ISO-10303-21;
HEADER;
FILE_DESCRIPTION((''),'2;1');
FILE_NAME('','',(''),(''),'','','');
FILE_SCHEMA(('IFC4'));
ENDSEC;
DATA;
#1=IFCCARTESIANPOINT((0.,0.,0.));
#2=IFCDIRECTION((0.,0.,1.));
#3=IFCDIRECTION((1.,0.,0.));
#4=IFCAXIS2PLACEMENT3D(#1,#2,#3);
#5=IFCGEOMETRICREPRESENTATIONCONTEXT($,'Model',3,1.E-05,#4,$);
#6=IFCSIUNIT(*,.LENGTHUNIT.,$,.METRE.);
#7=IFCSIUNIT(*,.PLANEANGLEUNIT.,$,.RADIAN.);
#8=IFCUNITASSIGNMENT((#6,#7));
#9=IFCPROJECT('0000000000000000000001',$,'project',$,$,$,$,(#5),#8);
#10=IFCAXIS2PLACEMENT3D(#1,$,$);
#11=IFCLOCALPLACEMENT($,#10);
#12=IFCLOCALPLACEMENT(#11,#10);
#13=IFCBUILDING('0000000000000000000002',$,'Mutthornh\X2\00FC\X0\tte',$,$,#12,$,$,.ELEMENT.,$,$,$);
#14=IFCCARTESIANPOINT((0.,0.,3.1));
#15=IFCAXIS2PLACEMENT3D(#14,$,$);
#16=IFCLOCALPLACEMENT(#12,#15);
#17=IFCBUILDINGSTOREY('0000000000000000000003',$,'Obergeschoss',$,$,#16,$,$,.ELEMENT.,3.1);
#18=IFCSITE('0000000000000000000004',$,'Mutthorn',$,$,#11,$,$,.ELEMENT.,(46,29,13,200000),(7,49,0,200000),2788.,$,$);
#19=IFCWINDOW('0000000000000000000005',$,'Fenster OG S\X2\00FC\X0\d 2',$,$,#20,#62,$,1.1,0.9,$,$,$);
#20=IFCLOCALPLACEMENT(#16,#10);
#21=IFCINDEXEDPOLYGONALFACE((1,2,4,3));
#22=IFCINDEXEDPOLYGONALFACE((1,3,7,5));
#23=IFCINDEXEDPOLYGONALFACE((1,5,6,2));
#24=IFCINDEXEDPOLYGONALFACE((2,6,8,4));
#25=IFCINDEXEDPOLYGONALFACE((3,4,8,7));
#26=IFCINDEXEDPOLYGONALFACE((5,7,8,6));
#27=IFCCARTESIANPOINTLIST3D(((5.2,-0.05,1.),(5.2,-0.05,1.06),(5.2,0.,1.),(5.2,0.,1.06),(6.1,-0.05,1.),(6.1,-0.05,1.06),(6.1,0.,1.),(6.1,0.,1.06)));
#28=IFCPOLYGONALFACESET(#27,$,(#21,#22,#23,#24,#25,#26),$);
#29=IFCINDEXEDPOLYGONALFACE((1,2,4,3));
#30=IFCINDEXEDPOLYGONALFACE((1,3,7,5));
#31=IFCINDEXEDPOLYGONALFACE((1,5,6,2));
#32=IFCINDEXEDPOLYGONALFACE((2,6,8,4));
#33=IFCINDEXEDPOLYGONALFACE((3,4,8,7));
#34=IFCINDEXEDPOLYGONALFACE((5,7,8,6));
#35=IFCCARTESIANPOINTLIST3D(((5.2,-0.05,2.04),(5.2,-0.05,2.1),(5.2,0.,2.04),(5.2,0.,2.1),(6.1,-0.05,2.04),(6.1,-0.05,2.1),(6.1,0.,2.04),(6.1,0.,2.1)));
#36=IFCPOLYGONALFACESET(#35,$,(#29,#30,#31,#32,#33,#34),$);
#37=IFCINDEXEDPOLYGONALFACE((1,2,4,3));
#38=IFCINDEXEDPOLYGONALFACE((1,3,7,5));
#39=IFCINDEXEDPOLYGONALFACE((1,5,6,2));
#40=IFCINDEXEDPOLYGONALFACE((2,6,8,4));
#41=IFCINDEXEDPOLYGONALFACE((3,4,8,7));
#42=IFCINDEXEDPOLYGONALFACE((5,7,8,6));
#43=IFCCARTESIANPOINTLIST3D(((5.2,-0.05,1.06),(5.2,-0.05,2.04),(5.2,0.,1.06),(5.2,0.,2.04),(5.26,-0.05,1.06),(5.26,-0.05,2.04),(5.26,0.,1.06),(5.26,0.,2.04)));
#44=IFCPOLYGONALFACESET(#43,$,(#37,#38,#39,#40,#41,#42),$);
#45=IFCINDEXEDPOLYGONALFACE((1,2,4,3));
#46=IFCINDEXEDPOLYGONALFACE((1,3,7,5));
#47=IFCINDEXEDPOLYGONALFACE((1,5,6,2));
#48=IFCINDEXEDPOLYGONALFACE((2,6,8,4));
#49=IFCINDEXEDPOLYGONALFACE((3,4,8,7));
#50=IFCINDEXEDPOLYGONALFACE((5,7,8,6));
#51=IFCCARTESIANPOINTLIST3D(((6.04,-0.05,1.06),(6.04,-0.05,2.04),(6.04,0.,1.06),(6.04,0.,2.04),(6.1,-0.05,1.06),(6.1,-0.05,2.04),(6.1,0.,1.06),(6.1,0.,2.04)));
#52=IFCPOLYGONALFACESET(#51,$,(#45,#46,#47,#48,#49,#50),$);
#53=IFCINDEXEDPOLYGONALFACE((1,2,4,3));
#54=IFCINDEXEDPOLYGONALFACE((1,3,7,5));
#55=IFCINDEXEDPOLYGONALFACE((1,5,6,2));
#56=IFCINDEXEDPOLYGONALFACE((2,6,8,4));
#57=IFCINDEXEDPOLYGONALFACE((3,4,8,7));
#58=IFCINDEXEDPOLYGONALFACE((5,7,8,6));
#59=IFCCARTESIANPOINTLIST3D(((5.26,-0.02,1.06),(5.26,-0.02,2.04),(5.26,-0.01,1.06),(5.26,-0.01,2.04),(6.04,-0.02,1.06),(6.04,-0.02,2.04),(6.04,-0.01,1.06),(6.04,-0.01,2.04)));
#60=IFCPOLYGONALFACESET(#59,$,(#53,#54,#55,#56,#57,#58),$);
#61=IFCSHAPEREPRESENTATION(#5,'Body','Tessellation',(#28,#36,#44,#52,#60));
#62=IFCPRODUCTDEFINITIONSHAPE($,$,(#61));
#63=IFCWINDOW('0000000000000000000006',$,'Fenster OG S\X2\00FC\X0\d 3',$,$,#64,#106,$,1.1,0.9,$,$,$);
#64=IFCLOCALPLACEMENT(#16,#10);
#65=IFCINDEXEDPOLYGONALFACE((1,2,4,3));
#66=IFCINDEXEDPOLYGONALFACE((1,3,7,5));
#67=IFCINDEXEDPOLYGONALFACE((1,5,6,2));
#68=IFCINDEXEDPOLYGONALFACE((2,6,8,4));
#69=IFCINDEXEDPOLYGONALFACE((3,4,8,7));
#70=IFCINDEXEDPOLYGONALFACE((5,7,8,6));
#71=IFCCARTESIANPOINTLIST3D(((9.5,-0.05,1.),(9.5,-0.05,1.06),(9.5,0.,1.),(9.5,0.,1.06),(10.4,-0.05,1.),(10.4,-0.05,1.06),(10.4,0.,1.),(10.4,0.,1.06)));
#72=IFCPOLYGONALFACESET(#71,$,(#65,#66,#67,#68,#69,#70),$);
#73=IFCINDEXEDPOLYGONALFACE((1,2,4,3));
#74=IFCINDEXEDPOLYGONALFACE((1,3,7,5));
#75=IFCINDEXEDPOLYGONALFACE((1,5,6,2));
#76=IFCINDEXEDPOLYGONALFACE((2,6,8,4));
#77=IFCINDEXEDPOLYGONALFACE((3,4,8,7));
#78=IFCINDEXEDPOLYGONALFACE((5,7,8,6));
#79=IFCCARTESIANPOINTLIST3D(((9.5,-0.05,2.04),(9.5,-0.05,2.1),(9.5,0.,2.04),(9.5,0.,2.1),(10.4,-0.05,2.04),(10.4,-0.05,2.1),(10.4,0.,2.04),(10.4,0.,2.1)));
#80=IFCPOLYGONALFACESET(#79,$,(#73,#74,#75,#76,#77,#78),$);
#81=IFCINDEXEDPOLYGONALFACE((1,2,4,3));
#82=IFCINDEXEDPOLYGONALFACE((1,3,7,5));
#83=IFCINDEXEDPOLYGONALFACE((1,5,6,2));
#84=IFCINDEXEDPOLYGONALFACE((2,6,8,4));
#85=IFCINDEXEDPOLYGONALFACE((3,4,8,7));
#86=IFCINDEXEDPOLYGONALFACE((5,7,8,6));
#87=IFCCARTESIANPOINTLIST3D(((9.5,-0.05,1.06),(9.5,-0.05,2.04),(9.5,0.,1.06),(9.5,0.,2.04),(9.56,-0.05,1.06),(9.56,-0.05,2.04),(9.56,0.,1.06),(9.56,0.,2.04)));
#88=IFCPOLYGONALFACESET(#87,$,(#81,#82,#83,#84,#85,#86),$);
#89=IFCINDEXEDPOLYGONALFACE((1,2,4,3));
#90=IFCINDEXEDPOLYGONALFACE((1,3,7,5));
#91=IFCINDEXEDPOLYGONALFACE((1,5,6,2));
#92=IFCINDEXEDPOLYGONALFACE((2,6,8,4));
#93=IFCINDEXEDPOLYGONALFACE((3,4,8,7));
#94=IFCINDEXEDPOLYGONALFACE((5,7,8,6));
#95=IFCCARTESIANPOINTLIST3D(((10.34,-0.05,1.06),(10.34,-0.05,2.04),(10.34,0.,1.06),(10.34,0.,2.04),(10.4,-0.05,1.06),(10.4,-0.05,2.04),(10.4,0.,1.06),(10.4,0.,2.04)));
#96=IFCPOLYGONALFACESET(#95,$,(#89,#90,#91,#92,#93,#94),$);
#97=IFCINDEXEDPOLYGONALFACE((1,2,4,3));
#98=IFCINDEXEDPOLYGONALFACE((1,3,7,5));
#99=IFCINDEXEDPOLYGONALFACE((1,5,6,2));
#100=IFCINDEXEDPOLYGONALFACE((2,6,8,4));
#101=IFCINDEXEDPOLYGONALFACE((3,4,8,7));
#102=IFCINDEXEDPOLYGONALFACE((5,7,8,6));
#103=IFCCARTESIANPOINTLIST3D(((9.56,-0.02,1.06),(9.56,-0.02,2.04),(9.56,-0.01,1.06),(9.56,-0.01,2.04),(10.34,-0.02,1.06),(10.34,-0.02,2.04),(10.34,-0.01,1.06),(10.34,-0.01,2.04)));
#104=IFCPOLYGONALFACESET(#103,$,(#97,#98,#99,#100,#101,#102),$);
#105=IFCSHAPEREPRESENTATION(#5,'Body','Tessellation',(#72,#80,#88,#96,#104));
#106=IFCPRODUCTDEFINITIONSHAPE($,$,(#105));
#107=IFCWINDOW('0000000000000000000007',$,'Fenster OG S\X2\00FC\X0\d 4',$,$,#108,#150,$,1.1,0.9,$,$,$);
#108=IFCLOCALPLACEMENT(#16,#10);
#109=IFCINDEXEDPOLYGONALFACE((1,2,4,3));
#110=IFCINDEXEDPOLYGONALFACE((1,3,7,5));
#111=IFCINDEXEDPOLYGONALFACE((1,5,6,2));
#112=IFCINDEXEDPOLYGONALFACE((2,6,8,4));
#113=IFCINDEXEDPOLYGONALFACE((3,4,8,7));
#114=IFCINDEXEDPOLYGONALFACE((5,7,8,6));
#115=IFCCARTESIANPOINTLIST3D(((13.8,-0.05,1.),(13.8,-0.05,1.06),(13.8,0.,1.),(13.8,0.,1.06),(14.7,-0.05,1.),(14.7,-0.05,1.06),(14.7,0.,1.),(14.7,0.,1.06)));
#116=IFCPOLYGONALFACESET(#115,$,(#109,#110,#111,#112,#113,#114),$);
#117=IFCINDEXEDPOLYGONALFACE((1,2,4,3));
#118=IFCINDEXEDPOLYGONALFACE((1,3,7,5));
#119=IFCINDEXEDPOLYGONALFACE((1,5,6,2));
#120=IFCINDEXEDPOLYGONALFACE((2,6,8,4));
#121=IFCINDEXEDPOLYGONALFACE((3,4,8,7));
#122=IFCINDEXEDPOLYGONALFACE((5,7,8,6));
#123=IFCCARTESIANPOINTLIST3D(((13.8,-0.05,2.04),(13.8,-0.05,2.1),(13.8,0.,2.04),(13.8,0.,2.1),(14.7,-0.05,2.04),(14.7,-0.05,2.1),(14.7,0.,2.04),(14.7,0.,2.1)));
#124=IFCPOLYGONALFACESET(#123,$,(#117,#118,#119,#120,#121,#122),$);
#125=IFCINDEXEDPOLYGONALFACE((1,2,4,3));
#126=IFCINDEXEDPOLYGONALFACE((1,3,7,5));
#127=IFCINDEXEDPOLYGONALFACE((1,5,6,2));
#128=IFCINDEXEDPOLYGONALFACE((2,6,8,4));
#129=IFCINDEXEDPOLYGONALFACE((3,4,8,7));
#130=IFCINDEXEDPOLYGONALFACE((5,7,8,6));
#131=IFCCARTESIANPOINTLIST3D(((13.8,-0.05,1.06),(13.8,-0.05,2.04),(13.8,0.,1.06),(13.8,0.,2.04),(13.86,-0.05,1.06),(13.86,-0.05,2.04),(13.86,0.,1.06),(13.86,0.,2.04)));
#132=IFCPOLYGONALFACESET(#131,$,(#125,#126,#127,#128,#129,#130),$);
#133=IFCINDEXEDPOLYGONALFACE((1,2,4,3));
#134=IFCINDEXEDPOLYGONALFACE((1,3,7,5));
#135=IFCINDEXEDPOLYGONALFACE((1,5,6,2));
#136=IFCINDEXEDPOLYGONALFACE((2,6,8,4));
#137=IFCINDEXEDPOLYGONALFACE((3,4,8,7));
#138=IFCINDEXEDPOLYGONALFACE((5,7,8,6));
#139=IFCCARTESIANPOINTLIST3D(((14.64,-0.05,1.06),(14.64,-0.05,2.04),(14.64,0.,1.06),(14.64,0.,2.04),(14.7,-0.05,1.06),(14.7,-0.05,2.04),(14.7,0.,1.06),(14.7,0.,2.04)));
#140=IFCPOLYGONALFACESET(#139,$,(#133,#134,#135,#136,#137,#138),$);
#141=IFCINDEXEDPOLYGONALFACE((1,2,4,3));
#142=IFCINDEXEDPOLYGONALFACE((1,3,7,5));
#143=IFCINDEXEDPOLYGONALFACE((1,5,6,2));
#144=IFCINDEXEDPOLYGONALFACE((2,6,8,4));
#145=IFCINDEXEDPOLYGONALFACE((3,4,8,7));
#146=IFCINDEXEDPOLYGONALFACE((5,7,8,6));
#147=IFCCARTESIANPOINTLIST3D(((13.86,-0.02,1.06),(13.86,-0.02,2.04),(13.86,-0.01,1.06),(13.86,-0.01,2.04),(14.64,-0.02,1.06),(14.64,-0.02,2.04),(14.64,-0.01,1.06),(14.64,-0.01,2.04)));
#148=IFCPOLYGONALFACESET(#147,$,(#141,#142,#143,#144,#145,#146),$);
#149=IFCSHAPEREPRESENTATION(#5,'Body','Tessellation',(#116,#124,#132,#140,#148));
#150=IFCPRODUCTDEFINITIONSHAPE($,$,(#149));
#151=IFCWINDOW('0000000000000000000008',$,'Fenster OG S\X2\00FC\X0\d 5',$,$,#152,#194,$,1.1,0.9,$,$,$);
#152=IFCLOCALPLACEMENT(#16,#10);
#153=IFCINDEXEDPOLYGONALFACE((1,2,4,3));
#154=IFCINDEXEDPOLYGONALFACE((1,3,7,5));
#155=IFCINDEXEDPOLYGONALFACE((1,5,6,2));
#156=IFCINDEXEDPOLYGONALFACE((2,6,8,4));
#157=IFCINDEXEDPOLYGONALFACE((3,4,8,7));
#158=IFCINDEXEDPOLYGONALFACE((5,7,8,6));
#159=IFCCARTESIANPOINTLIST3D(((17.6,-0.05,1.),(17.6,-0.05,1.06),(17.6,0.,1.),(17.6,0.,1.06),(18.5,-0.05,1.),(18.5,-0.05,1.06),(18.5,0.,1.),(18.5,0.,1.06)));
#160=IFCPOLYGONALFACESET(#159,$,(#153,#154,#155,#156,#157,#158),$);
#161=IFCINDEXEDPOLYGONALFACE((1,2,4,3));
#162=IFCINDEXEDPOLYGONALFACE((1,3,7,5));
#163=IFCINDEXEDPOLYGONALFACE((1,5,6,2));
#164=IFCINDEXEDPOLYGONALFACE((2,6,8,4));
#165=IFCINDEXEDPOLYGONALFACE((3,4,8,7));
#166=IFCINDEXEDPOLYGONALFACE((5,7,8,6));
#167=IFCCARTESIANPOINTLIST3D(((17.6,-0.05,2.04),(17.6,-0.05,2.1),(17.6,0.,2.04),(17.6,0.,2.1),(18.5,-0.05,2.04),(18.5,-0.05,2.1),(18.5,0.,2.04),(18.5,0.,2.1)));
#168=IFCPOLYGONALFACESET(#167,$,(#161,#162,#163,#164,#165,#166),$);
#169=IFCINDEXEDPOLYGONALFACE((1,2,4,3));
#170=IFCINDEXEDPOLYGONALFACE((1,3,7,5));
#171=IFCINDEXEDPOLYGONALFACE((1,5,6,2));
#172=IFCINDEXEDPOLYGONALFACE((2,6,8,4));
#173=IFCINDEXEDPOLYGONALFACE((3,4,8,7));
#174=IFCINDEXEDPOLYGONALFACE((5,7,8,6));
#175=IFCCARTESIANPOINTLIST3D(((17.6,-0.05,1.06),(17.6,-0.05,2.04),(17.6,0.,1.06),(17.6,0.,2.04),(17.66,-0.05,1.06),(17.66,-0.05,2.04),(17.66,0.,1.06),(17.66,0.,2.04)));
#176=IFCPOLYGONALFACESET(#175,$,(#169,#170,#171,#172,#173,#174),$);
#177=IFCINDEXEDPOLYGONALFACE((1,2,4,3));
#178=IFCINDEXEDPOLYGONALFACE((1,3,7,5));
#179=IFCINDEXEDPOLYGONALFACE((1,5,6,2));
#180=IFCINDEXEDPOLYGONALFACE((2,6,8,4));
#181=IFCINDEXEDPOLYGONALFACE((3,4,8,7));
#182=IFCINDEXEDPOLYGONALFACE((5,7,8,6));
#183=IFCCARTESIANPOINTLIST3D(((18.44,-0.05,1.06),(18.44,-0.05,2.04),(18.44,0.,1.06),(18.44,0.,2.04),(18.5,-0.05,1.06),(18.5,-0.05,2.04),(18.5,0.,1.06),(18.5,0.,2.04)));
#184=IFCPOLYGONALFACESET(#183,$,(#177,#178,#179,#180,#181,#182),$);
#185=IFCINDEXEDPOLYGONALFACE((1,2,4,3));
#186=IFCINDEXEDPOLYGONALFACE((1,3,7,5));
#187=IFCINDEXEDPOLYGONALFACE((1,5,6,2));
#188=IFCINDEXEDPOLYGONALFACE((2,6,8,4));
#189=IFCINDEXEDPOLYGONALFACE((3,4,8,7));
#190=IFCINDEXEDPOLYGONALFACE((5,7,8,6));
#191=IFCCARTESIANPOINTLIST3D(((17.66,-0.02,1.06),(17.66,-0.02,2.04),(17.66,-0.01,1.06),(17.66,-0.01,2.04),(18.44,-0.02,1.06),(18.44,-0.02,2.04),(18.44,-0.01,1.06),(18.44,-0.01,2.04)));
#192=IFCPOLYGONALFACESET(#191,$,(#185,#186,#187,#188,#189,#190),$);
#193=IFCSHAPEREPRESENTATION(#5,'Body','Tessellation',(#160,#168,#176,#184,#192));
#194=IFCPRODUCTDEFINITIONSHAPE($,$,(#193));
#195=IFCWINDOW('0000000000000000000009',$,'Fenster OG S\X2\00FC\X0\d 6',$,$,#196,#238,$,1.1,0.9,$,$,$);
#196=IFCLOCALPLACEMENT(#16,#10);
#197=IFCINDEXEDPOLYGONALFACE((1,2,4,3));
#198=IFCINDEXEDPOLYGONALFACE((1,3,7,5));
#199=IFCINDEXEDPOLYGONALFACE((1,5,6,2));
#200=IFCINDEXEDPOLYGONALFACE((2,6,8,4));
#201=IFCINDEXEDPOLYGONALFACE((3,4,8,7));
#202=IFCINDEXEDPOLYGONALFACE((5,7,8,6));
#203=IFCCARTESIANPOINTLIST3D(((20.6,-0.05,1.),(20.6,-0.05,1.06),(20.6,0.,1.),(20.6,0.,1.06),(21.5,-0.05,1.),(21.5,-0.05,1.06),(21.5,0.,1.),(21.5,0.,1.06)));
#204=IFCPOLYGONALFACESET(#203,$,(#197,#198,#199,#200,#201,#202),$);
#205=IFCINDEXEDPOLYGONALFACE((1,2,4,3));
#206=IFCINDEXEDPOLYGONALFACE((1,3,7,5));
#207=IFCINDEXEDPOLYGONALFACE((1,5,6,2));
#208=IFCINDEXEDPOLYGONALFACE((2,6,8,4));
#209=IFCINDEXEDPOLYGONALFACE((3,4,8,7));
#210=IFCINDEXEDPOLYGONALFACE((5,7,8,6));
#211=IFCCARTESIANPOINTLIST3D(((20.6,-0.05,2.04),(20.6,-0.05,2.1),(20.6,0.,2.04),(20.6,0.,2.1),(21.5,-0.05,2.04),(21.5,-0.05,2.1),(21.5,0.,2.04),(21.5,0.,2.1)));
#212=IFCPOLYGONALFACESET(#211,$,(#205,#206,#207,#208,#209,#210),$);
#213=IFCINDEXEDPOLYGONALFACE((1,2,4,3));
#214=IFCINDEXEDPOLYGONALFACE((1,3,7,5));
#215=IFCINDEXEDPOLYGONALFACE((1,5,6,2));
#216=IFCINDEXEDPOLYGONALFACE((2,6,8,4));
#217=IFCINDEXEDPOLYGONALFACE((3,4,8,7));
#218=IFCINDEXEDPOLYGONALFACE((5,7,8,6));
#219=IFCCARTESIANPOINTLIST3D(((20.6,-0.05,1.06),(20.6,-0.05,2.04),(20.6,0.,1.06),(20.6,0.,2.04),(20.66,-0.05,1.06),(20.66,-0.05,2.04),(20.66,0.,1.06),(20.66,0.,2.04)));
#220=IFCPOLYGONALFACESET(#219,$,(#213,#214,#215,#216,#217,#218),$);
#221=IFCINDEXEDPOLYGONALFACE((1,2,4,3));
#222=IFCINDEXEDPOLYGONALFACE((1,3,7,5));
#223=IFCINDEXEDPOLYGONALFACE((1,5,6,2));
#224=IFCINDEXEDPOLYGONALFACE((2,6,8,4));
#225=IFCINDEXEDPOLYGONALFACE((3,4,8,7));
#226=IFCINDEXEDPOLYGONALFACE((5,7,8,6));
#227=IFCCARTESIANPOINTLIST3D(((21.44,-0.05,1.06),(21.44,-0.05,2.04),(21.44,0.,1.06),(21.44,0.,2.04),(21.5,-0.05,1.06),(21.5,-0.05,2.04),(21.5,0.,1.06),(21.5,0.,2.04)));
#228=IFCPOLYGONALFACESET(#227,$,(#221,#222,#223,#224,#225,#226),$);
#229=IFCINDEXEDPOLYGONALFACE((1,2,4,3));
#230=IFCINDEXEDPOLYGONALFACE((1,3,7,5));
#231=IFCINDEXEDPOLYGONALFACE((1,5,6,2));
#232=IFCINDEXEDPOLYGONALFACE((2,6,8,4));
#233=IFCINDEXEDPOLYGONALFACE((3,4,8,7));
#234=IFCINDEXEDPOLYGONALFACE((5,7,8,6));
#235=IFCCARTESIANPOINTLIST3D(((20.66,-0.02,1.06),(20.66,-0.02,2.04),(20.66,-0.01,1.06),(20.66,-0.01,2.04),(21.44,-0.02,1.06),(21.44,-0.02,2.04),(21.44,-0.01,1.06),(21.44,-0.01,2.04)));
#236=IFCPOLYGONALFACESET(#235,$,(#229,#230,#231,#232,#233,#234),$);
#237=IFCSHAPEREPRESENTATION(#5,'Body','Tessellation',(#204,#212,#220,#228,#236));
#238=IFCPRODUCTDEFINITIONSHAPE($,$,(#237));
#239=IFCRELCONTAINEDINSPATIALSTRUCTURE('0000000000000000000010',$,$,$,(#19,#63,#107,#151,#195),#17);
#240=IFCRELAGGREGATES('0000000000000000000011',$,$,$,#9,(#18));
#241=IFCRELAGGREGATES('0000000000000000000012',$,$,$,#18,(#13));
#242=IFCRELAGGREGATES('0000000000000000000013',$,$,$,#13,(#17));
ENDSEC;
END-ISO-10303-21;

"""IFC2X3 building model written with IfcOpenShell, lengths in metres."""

from ifc_helpers import new_model, si_unit, frame, frame_2d, origin, origin_with_axes, place, context, project, spatial, rectangle, extrude, element, save


model = new_model("IFC2X3")

# Units and contexts
model_context = context("Model", 3, precision=1e-05, world=origin_with_axes())
ifc_project = project(units=[si_unit("LENGTHUNIT", "METRE"), si_unit("PLANEANGLEUNIT", "RADIAN")], contexts=[model_context])

# Site, building, storey
site_placement = place(None, origin())
site = spatial("IfcSite", under=ifc_project, at=site_placement, Name="Mutthorn", CompositionType="ELEMENT", RefLatitude=(46, 29, 13, 200000), RefLongitude=(7, 49, 0, 200000), RefElevation=2788.0)
building_placement = place(site_placement, origin())
building = spatial("IfcBuilding", under=site, at=building_placement, Name="Mutthornhütte", CompositionType="ELEMENT")
storey_placement = place(building_placement, frame((0.0, 0.0, 3.1)))
storey = spatial("IfcBuildingStorey", under=building, at=storey_placement, Name="Obergeschoss", CompositionType="ELEMENT", Elevation=3.1)

# Windows
window_1_placement = place(storey_placement, origin())
element("IfcWindow", 1, at=window_1_placement, inside=storey, Name="Fenster OG Süd 2", OverallHeight=1.1, OverallWidth=0.9, context=model_context, shape_type="SweptSolid", body=[
    extrude(rectangle(XDim=0.9, YDim=0.05, at=frame_2d((0.45, 0.025))), frame((5.2, -0.05, 1.0)), (0.0, 0.0, 1.0), 0.06),
    extrude(rectangle(XDim=0.9, YDim=0.05, at=frame_2d((0.45, 0.025))), frame((5.2, -0.05, 2.04)), (0.0, 0.0, 1.0), 0.06),
    extrude(rectangle(XDim=0.06, YDim=0.05, at=frame_2d((0.03, 0.025))), frame((5.2, -0.05, 1.06)), (0.0, 0.0, 1.0), 0.98),
    extrude(rectangle(XDim=0.06, YDim=0.05, at=frame_2d((0.03, 0.025))), frame((6.04, -0.05, 1.06)), (0.0, 0.0, 1.0), 0.98),
    extrude(rectangle(XDim=0.78, YDim=0.01, at=frame_2d((0.39, 0.005))), frame((5.26, -0.02, 1.06)), (0.0, 0.0, 1.0), 0.98),
])
window_2_placement = place(storey_placement, origin())
element("IfcWindow", 2, at=window_2_placement, inside=storey, Name="Fenster OG Süd 3", OverallHeight=1.1, OverallWidth=0.9, context=model_context, shape_type="SweptSolid", body=[
    extrude(rectangle(XDim=0.9, YDim=0.05, at=frame_2d((0.45, 0.025))), frame((9.5, -0.05, 1.0)), (0.0, 0.0, 1.0), 0.06),
    extrude(rectangle(XDim=0.9, YDim=0.05, at=frame_2d((0.45, 0.025))), frame((9.5, -0.05, 2.04)), (0.0, 0.0, 1.0), 0.06),
    extrude(rectangle(XDim=0.06, YDim=0.05, at=frame_2d((0.03, 0.025))), frame((9.5, -0.05, 1.06)), (0.0, 0.0, 1.0), 0.98),
    extrude(rectangle(XDim=0.06, YDim=0.05, at=frame_2d((0.03, 0.025))), frame((10.34, -0.05, 1.06)), (0.0, 0.0, 1.0), 0.98),
    extrude(rectangle(XDim=0.78, YDim=0.01, at=frame_2d((0.39, 0.005))), frame((9.56, -0.02, 1.06)), (0.0, 0.0, 1.0), 0.98),
])
window_3_placement = place(storey_placement, origin())
element("IfcWindow", 3, at=window_3_placement, inside=storey, Name="Fenster OG Süd 4", OverallHeight=1.1, OverallWidth=0.9, context=model_context, shape_type="SweptSolid", body=[
    extrude(rectangle(XDim=0.9, YDim=0.05, at=frame_2d((0.45, 0.025))), frame((13.8, -0.05, 1.0)), (0.0, 0.0, 1.0), 0.06),
    extrude(rectangle(XDim=0.9, YDim=0.05, at=frame_2d((0.45, 0.025))), frame((13.8, -0.05, 2.04)), (0.0, 0.0, 1.0), 0.06),
    extrude(rectangle(XDim=0.06, YDim=0.05, at=frame_2d((0.03, 0.025))), frame((13.8, -0.05, 1.06)), (0.0, 0.0, 1.0), 0.98),
    extrude(rectangle(XDim=0.06, YDim=0.05, at=frame_2d((0.03, 0.025))), frame((14.64, -0.05, 1.06)), (0.0, 0.0, 1.0), 0.98),
    extrude(rectangle(XDim=0.78, YDim=0.01, at=frame_2d((0.39, 0.005))), frame((13.86, -0.02, 1.06)), (0.0, 0.0, 1.0), 0.98),
])
window_4_placement = place(storey_placement, origin())
element("IfcWindow", 4, at=window_4_placement, inside=storey, Name="Fenster OG Süd 5", OverallHeight=1.1, OverallWidth=0.9, context=model_context, shape_type="SweptSolid", body=[
    extrude(rectangle(XDim=0.9, YDim=0.05, at=frame_2d((0.45, 0.025))), frame((17.6, -0.05, 1.0)), (0.0, 0.0, 1.0), 0.06),
    extrude(rectangle(XDim=0.9, YDim=0.05, at=frame_2d((0.45, 0.025))), frame((17.6, -0.05, 2.04)), (0.0, 0.0, 1.0), 0.06),
    extrude(rectangle(XDim=0.06, YDim=0.05, at=frame_2d((0.03, 0.025))), frame((17.6, -0.05, 1.06)), (0.0, 0.0, 1.0), 0.98),
    extrude(rectangle(XDim=0.06, YDim=0.05, at=frame_2d((0.03, 0.025))), frame((18.44, -0.05, 1.06)), (0.0, 0.0, 1.0), 0.98),
    extrude(rectangle(XDim=0.78, YDim=0.01, at=frame_2d((0.39, 0.005))), frame((17.66, -0.02, 1.06)), (0.0, 0.0, 1.0), 0.98),
])
window_5_placement = place(storey_placement, origin())
element("IfcWindow", 5, at=window_5_placement, inside=storey, Name="Fenster OG Süd 6", OverallHeight=1.1, OverallWidth=0.9, context=model_context, shape_type="SweptSolid", body=[
    extrude(rectangle(XDim=0.9, YDim=0.05, at=frame_2d((0.45, 0.025))), frame((20.6, -0.05, 1.0)), (0.0, 0.0, 1.0), 0.06),
    extrude(rectangle(XDim=0.9, YDim=0.05, at=frame_2d((0.45, 0.025))), frame((20.6, -0.05, 2.04)), (0.0, 0.0, 1.0), 0.06),
    extrude(rectangle(XDim=0.06, YDim=0.05, at=frame_2d((0.03, 0.025))), frame((20.6, -0.05, 1.06)), (0.0, 0.0, 1.0), 0.98),
    extrude(rectangle(XDim=0.06, YDim=0.05, at=frame_2d((0.03, 0.025))), frame((21.44, -0.05, 1.06)), (0.0, 0.0, 1.0), 0.98),
    extrude(rectangle(XDim=0.78, YDim=0.01, at=frame_2d((0.39, 0.005))), frame((20.66, -0.02, 1.06)), (0.0, 0.0, 1.0), 0.98),
])

save(model, "model.ifc")
